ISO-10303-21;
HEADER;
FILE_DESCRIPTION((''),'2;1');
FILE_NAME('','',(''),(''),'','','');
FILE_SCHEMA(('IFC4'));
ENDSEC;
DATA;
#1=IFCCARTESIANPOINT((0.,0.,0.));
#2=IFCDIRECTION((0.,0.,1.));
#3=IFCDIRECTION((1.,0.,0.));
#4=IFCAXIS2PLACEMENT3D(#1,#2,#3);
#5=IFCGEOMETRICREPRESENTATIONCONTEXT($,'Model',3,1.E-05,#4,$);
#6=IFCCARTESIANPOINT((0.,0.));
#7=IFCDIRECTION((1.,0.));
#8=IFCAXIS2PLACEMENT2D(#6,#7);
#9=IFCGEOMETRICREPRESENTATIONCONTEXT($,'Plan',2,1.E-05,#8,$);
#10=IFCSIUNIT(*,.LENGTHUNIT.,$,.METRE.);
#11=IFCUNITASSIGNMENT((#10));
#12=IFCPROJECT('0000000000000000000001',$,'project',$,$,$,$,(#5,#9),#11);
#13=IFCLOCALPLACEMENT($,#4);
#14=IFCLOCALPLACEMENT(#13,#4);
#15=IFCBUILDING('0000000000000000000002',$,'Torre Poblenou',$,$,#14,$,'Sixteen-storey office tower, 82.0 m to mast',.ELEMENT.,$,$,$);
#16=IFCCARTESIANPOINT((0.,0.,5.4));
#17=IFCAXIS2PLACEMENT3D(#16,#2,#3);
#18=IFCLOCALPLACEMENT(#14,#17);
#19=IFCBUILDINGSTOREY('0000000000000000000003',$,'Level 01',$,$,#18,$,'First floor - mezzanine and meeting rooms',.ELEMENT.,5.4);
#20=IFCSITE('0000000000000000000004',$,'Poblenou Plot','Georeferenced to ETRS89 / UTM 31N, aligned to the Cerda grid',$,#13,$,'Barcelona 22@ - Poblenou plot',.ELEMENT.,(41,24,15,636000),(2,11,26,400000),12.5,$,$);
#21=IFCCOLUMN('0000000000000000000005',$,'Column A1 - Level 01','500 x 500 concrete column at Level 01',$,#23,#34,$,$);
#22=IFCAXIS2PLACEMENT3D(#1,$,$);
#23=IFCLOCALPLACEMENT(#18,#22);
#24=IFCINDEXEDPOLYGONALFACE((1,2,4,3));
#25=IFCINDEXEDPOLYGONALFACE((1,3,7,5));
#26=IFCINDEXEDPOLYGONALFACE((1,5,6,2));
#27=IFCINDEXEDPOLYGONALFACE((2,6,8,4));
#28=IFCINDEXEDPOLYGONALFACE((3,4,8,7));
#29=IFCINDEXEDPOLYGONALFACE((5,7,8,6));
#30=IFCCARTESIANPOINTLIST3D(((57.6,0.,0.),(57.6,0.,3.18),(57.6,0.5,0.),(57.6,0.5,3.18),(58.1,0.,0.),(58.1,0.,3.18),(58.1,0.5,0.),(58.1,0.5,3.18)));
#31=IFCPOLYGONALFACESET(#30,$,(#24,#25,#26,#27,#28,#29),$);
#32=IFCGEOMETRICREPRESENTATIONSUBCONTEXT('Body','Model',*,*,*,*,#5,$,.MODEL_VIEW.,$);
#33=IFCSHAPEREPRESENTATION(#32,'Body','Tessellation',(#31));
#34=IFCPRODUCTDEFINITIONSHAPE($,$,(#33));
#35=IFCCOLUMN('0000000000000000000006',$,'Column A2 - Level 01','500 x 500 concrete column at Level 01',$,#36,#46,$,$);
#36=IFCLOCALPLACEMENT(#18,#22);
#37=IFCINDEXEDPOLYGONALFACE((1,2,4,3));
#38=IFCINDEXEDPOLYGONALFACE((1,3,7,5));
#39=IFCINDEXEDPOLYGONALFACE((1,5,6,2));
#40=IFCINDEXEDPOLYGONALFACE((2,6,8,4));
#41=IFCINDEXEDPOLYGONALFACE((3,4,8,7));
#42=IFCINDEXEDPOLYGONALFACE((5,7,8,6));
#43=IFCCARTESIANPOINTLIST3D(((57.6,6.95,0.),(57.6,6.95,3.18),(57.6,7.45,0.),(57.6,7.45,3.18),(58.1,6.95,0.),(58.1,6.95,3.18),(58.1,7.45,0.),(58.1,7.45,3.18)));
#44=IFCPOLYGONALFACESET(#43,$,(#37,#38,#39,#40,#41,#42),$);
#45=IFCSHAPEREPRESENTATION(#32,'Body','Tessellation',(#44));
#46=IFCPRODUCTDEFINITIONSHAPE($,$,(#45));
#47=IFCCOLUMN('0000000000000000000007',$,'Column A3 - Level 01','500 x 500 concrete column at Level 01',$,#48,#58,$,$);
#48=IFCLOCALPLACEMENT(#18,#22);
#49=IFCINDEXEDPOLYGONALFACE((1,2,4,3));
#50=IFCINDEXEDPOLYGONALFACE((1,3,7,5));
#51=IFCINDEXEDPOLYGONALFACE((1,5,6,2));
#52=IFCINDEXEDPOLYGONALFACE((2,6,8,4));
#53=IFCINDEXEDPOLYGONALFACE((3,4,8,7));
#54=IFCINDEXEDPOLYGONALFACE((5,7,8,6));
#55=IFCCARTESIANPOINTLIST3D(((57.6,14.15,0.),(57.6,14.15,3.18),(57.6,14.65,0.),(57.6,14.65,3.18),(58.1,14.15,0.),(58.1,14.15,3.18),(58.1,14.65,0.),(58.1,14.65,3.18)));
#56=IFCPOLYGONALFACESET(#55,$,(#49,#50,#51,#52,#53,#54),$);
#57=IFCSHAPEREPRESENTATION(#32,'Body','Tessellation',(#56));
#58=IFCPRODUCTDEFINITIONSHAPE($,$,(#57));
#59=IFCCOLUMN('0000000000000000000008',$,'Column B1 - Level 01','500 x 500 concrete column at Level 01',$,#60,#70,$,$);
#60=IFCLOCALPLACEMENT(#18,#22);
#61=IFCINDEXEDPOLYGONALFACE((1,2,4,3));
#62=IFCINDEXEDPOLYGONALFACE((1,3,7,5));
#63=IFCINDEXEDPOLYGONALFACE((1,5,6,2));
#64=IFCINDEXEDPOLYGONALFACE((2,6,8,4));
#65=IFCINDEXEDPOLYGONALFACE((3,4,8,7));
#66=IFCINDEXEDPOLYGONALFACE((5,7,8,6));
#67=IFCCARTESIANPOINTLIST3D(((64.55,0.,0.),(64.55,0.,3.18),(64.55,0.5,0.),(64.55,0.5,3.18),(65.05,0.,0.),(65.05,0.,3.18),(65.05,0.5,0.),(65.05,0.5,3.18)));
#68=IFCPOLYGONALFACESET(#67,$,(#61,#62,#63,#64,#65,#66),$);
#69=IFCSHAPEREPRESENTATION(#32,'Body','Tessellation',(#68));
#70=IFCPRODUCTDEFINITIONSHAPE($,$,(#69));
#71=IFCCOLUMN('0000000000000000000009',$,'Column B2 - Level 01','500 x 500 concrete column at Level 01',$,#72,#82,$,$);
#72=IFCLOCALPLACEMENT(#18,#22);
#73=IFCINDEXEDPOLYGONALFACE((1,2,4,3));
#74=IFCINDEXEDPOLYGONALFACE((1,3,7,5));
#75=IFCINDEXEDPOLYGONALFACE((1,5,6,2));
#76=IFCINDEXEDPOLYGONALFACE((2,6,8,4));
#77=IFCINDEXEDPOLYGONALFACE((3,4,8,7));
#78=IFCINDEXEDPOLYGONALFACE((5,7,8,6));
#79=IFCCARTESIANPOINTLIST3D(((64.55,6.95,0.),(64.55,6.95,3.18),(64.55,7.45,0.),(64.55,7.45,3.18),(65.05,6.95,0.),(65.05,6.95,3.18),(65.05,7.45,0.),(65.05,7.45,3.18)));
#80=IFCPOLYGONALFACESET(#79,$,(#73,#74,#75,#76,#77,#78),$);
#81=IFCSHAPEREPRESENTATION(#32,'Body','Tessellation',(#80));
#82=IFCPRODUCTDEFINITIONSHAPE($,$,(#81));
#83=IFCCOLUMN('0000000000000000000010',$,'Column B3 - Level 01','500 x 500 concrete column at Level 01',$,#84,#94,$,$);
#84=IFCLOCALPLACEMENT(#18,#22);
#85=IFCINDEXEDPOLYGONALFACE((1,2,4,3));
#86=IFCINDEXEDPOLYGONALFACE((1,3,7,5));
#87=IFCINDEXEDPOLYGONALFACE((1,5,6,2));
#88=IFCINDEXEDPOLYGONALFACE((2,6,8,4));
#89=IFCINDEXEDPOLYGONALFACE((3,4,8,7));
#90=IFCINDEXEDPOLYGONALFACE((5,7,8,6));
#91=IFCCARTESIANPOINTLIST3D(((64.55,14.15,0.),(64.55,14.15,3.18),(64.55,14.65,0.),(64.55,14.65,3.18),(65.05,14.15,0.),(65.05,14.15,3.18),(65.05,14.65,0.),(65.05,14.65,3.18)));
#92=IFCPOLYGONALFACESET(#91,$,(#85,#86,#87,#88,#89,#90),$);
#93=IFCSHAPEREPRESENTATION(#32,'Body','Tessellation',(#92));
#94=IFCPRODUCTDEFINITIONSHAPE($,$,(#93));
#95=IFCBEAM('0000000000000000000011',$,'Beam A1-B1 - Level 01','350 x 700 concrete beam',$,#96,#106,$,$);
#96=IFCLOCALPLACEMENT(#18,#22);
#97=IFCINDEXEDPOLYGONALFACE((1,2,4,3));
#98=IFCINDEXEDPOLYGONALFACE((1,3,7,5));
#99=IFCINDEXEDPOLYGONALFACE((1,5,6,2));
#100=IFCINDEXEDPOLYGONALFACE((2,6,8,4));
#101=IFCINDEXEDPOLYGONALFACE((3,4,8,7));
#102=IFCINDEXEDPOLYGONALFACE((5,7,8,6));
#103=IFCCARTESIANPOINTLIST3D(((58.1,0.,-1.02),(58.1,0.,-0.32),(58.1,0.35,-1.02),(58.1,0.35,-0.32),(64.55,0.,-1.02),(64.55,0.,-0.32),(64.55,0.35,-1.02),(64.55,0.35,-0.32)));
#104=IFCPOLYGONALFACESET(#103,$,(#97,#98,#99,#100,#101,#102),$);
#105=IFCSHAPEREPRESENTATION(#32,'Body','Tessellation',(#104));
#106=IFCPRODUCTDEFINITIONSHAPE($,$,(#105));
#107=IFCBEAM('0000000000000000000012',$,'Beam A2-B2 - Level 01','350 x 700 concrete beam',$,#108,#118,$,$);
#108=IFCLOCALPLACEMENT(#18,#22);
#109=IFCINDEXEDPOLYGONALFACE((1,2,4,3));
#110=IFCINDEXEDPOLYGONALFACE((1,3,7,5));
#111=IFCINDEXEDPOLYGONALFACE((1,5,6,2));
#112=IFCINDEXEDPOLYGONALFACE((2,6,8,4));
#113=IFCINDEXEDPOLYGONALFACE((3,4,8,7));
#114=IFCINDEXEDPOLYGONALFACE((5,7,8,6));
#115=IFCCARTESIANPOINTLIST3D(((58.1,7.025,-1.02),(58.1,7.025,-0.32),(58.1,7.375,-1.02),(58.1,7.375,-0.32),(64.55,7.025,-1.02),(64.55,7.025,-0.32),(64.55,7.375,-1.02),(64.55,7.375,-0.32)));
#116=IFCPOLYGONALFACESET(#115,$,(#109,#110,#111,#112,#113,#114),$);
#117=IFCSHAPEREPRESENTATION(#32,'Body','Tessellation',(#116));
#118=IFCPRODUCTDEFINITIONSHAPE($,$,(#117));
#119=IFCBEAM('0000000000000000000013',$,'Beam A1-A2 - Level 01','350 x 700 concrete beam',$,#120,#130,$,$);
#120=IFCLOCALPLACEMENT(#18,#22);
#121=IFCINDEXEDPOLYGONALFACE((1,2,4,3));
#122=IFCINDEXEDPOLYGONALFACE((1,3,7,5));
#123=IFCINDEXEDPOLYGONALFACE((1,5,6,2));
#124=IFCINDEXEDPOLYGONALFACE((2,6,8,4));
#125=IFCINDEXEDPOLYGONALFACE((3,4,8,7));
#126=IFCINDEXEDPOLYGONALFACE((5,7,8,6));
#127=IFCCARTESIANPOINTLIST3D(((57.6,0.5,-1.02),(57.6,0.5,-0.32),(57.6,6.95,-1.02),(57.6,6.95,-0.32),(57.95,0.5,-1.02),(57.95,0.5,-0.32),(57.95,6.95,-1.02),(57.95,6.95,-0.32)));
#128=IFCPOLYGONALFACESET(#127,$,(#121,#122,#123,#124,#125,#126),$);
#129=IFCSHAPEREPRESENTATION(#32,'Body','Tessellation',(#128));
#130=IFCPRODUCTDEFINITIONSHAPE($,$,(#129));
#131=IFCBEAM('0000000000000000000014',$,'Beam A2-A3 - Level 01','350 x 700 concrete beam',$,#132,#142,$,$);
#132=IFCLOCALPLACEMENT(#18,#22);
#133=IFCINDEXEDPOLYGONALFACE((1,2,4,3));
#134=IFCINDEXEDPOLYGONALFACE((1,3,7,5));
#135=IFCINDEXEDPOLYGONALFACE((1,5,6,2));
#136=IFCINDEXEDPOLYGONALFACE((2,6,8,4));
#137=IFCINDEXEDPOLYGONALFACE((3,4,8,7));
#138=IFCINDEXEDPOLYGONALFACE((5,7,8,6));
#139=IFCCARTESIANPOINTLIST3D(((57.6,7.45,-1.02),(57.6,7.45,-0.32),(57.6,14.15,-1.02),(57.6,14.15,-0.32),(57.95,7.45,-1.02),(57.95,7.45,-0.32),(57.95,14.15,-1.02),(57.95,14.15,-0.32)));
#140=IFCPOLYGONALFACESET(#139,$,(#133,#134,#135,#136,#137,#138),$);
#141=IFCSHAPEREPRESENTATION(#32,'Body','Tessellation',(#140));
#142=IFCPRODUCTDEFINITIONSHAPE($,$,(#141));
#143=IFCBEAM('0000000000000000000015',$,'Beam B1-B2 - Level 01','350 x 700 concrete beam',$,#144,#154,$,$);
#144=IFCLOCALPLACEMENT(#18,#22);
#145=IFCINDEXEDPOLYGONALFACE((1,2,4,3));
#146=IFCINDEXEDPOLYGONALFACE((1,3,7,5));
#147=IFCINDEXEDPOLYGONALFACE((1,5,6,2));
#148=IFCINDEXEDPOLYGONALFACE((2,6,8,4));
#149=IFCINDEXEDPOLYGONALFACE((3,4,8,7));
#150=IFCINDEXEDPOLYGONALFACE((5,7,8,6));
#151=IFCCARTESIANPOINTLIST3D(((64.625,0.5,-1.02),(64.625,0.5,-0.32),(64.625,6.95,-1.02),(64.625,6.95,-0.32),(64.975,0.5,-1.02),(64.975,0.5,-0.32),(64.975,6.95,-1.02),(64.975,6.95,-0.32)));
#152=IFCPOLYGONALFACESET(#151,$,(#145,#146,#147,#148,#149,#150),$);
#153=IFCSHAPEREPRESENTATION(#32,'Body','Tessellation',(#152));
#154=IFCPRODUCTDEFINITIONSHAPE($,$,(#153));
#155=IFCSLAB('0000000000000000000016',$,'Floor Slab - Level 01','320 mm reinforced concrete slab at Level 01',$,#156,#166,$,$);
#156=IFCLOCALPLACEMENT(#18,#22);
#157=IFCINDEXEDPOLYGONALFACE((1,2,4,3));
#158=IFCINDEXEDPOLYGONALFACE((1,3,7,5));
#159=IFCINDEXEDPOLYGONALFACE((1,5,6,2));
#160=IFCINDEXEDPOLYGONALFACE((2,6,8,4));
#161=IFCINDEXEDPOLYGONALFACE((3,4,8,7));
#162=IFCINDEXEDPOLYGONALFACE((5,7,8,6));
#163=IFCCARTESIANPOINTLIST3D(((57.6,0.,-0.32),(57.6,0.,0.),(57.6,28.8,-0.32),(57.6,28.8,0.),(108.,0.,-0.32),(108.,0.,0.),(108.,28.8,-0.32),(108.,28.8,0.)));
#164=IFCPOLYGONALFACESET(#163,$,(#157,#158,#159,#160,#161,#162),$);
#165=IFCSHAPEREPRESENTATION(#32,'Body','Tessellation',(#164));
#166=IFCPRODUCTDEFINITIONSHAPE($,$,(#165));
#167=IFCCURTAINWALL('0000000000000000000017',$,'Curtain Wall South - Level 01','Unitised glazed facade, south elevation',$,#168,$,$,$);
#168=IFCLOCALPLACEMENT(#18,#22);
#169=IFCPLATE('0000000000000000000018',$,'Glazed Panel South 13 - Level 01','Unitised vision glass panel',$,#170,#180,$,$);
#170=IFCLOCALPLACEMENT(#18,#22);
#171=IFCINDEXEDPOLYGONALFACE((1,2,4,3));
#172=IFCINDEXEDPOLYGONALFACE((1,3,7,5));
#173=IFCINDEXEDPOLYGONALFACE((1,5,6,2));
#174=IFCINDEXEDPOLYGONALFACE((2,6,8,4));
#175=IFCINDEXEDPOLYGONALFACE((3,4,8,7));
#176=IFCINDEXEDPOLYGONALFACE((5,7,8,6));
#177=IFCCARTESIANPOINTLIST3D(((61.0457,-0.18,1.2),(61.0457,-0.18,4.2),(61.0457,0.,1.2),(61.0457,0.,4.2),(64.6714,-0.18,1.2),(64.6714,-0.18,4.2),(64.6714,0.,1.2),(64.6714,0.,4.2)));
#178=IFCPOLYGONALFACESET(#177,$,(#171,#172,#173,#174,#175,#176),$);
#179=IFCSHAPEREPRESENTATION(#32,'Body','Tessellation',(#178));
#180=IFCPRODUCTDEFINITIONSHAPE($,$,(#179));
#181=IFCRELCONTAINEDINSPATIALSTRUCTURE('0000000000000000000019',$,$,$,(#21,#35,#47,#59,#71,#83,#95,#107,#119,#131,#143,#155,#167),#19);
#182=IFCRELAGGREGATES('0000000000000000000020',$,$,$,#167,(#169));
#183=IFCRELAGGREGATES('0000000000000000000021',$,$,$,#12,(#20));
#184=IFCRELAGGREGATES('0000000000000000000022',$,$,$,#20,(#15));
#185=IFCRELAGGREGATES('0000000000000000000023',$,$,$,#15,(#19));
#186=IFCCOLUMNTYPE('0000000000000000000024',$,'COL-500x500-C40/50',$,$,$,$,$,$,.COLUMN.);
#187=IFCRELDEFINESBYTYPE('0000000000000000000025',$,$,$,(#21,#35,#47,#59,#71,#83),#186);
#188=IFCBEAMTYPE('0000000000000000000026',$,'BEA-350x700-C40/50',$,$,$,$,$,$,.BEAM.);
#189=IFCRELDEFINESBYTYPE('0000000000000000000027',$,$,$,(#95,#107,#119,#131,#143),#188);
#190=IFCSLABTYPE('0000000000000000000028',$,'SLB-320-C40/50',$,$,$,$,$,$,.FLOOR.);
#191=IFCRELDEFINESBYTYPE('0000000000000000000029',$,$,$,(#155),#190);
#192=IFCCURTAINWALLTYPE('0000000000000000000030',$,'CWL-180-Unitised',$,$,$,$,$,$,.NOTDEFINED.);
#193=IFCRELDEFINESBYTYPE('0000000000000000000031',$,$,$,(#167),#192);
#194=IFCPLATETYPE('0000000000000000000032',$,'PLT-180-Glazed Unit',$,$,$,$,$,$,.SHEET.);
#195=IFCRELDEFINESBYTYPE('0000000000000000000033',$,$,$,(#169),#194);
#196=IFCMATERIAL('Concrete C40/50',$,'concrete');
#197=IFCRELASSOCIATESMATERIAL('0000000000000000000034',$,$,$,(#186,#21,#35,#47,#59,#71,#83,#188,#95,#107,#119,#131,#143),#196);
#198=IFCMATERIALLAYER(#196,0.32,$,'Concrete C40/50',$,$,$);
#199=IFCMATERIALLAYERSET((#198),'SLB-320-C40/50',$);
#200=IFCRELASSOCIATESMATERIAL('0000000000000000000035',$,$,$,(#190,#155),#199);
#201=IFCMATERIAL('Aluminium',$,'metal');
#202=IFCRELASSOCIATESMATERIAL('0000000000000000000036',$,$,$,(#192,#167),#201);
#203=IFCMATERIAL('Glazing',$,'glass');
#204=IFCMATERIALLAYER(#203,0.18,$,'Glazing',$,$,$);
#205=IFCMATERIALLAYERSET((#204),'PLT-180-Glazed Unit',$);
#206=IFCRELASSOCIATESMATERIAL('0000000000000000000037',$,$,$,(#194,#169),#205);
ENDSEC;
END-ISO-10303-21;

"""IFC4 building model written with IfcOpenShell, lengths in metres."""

from ifc_helpers import new_model, si_unit, frame, origin_with_axes, origin_2d_with_axis, place, context, subcontext, project, spatial, line, indexed_curve, rectangle, outline, extrude, material, layer, layer_set, layer_usage, material_profile, profile_set, profile_usage, type_object, element, aggregate, save


model = new_model("IFC4")

# Units and contexts
model_context = context("Model", 3, precision=1e-05, world=origin_with_axes())
plan_context = context("Plan", 2, precision=1e-05, world=origin_2d_with_axis())
body_context = subcontext(model_context, "Body", "Model", "MODEL_VIEW")
ifc_project = project(units=[si_unit("LENGTHUNIT", "METRE")], contexts=[model_context, plan_context])

# Site, building, storey
site_placement = place(None, origin_with_axes())
site = spatial("IfcSite", under=ifc_project, at=site_placement, Name="Poblenou Plot", Description="Georeferenced to ETRS89 / UTM 31N, aligned to the Cerda grid", LongName="Barcelona 22@ - Poblenou plot", CompositionType="ELEMENT", RefLatitude=(41, 24, 15, 636000), RefLongitude=(2, 11, 26, 400000), RefElevation=12.5)
building_placement = place(site_placement, origin_with_axes())
building = spatial("IfcBuilding", under=site, at=building_placement, Name="Torre Poblenou", LongName="Sixteen-storey office tower, 82.0 m to mast", CompositionType="ELEMENT")
storey_placement = place(building_placement, frame((0.0, 0.0, 5.4), z_axis=(0.0, 0.0, 1.0), x_axis=(1.0, 0.0, 0.0)))
storey = spatial("IfcBuildingStorey", under=building, at=storey_placement, Name="Level 01", LongName="First floor - mezzanine and meeting rooms", CompositionType="ELEMENT", Elevation=5.4)

# Columns
ifc_material_1 = material(Name="Concrete C40/50", Category="concrete")
ifc_material_profile_1 = material_profile(ifc_material_1, rectangle(XDim=0.5, YDim=0.5))
ifc_profile_set_1 = profile_set([ifc_material_profile_1], Name="COL-500x500-C40/50")
ifc_profile_usage_1 = profile_usage(ifc_profile_set_1)
column_type = type_object("IfcColumnType", Name="COL-500x500-C40/50", PredefinedType="COLUMN", material=ifc_profile_set_1)
column_1_placement = place(storey_placement, frame((57.6, 0.0, 0.0), z_axis=(0.0, 0.0, 1.0), x_axis=(1.0, 0.0, 0.0)))
element("IfcColumn", 1, at=column_1_placement, inside=storey, type_object=column_type, material=ifc_profile_usage_1, Name="Column A1 - Level 01", Description="500 x 500 concrete column at Level 01", context=body_context, shape_type="SweptSolid", body=[
    extrude(outline(indexed_curve([(0.0, 0.0), (0.5, 0.0), (0.5, 0.5), (0.0, 0.5)], segments=[line(1, 2, 3, 4, 1)])), origin_with_axes(), (0.0, 0.0, 1.0), 3.18),
])
ifc_profile_usage_2 = profile_usage(ifc_profile_set_1)
column_2_placement = place(storey_placement, frame((57.6, 6.95, 0.0), z_axis=(0.0, 0.0, 1.0), x_axis=(1.0, 0.0, 0.0)))
element("IfcColumn", 2, at=column_2_placement, inside=storey, type_object=column_type, material=ifc_profile_usage_2, Name="Column A2 - Level 01", Description="500 x 500 concrete column at Level 01", context=body_context, shape_type="SweptSolid", body=[
    extrude(outline(indexed_curve([(0.0, 0.0), (0.5, 0.0), (0.5, 0.5), (0.0, 0.5)], segments=[line(1, 2, 3, 4, 1)])), origin_with_axes(), (0.0, 0.0, 1.0), 3.18),
])
ifc_profile_usage_3 = profile_usage(ifc_profile_set_1)
column_3_placement = place(storey_placement, frame((57.6, 14.15, 0.0), z_axis=(0.0, 0.0, 1.0), x_axis=(1.0, 0.0, 0.0)))
element("IfcColumn", 3, at=column_3_placement, inside=storey, type_object=column_type, material=ifc_profile_usage_3, Name="Column A3 - Level 01", Description="500 x 500 concrete column at Level 01", context=body_context, shape_type="SweptSolid", body=[
    extrude(outline(indexed_curve([(0.0, 0.0), (0.5, 0.0), (0.5, 0.5), (0.0, 0.5)], segments=[line(1, 2, 3, 4, 1)])), origin_with_axes(), (0.0, 0.0, 1.0), 3.18),
])
ifc_profile_usage_4 = profile_usage(ifc_profile_set_1)
column_4_placement = place(storey_placement, frame((64.55, 0.0, 0.0), z_axis=(0.0, 0.0, 1.0), x_axis=(1.0, 0.0, 0.0)))
element("IfcColumn", 4, at=column_4_placement, inside=storey, type_object=column_type, material=ifc_profile_usage_4, Name="Column B1 - Level 01", Description="500 x 500 concrete column at Level 01", context=body_context, shape_type="SweptSolid", body=[
    extrude(outline(indexed_curve([(0.0, 0.0), (0.5, 0.0), (0.5, 0.5), (0.0, 0.5)], segments=[line(1, 2, 3, 4, 1)])), origin_with_axes(), (0.0, 0.0, 1.0), 3.18),
])
ifc_profile_usage_5 = profile_usage(ifc_profile_set_1)
column_5_placement = place(storey_placement, frame((64.55, 6.95, 0.0), z_axis=(0.0, 0.0, 1.0), x_axis=(1.0, 0.0, 0.0)))
element("IfcColumn", 5, at=column_5_placement, inside=storey, type_object=column_type, material=ifc_profile_usage_5, Name="Column B2 - Level 01", Description="500 x 500 concrete column at Level 01", context=body_context, shape_type="SweptSolid", body=[
    extrude(outline(indexed_curve([(0.0, 0.0), (0.5, 0.0), (0.5, 0.5), (0.0, 0.5)], segments=[line(1, 2, 3, 4, 1)])), origin_with_axes(), (0.0, 0.0, 1.0), 3.18),
])
ifc_profile_usage_6 = profile_usage(ifc_profile_set_1)
column_6_placement = place(storey_placement, frame((64.55, 14.15, 0.0), z_axis=(0.0, 0.0, 1.0), x_axis=(1.0, 0.0, 0.0)))
element("IfcColumn", 6, at=column_6_placement, inside=storey, type_object=column_type, material=ifc_profile_usage_6, Name="Column B3 - Level 01", Description="500 x 500 concrete column at Level 01", context=body_context, shape_type="SweptSolid", body=[
    extrude(outline(indexed_curve([(0.0, 0.0), (0.5, 0.0), (0.5, 0.5), (0.0, 0.5)], segments=[line(1, 2, 3, 4, 1)])), origin_with_axes(), (0.0, 0.0, 1.0), 3.18),
])

# Beams
ifc_material_profile_2 = material_profile(ifc_material_1, rectangle(XDim=0.35, YDim=0.7))
ifc_profile_set_2 = profile_set([ifc_material_profile_2], Name="BEA-350x700-C40/50")
ifc_profile_usage_7 = profile_usage(ifc_profile_set_2)
beam_type = type_object("IfcBeamType", Name="BEA-350x700-C40/50", PredefinedType="BEAM", material=ifc_profile_set_2)
beam_1_placement = place(storey_placement, frame((58.1, 0.0, -1.02), z_axis=(0.0, 0.0, 1.0), x_axis=(1.0, 0.0, 0.0)))
element("IfcBeam", 7, at=beam_1_placement, inside=storey, type_object=beam_type, material=ifc_profile_usage_7, Name="Beam A1-B1 - Level 01", Description="350 x 700 concrete beam", context=body_context, shape_type="SweptSolid", body=[
    extrude(outline(indexed_curve([(0.0, 0.0), (6.45, 0.0), (6.45, 0.35), (0.0, 0.35)], segments=[line(1, 2, 3, 4, 1)])), origin_with_axes(), (0.0, 0.0, 1.0), 0.7),
])
ifc_profile_usage_8 = profile_usage(ifc_profile_set_2)
beam_2_placement = place(storey_placement, frame((58.1, 7.025, -1.02), z_axis=(0.0, 0.0, 1.0), x_axis=(1.0, 0.0, 0.0)))
element("IfcBeam", 8, at=beam_2_placement, inside=storey, type_object=beam_type, material=ifc_profile_usage_8, Name="Beam A2-B2 - Level 01", Description="350 x 700 concrete beam", context=body_context, shape_type="SweptSolid", body=[
    extrude(outline(indexed_curve([(0.0, 0.0), (6.45, 0.0), (6.45, 0.35), (0.0, 0.35)], segments=[line(1, 2, 3, 4, 1)])), origin_with_axes(), (0.0, 0.0, 1.0), 0.7),
])
ifc_profile_usage_9 = profile_usage(ifc_profile_set_2)
beam_3_placement = place(storey_placement, frame((57.95, 0.5, -1.02), z_axis=(0.0, 0.0, 1.0), x_axis=(0.0, 1.0, 0.0)))
element("IfcBeam", 9, at=beam_3_placement, inside=storey, type_object=beam_type, material=ifc_profile_usage_9, Name="Beam A1-A2 - Level 01", Description="350 x 700 concrete beam", context=body_context, shape_type="SweptSolid", body=[
    extrude(outline(indexed_curve([(0.0, 0.0), (6.45, 0.0), (6.45, 0.35), (0.0, 0.35)], segments=[line(1, 2, 3, 4, 1)])), origin_with_axes(), (0.0, 0.0, 1.0), 0.7),
])
ifc_profile_usage_10 = profile_usage(ifc_profile_set_2)
beam_4_placement = place(storey_placement, frame((57.95, 7.45, -1.02), z_axis=(0.0, 0.0, 1.0), x_axis=(0.0, 1.0, 0.0)))
element("IfcBeam", 10, at=beam_4_placement, inside=storey, type_object=beam_type, material=ifc_profile_usage_10, Name="Beam A2-A3 - Level 01", Description="350 x 700 concrete beam", context=body_context, shape_type="SweptSolid", body=[
    extrude(outline(indexed_curve([(0.0, 0.0), (6.7, 0.0), (6.7, 0.35), (0.0, 0.35)], segments=[line(1, 2, 3, 4, 1)])), origin_with_axes(), (0.0, 0.0, 1.0), 0.7),
])
ifc_profile_usage_11 = profile_usage(ifc_profile_set_2)
beam_5_placement = place(storey_placement, frame((64.975, 0.5, -1.02), z_axis=(0.0, 0.0, 1.0), x_axis=(0.0, 1.0, 0.0)))
element("IfcBeam", 11, at=beam_5_placement, inside=storey, type_object=beam_type, material=ifc_profile_usage_11, Name="Beam B1-B2 - Level 01", Description="350 x 700 concrete beam", context=body_context, shape_type="SweptSolid", body=[
    extrude(outline(indexed_curve([(0.0, 0.0), (6.45, 0.0), (6.45, 0.35), (0.0, 0.35)], segments=[line(1, 2, 3, 4, 1)])), origin_with_axes(), (0.0, 0.0, 1.0), 0.7),
])

# Slab
ifc_layer_1 = layer(ifc_material_1, 0.32, Name="Concrete C40/50")
ifc_layer_set_1 = layer_set([ifc_layer_1], Name="SLB-320-C40/50")
ifc_layer_usage_1 = layer_usage(ifc_layer_set_1, "AXIS3", "POSITIVE", 0.0)
slab_type = type_object("IfcSlabType", Name="SLB-320-C40/50", PredefinedType="FLOOR", material=ifc_layer_set_1)
slab_placement = place(storey_placement, frame((57.6, 0.0, -0.32), z_axis=(0.0, 0.0, 1.0), x_axis=(1.0, 0.0, 0.0)))
element("IfcSlab", 12, at=slab_placement, inside=storey, type_object=slab_type, material=ifc_layer_usage_1, Name="Floor Slab - Level 01", Description="320 mm reinforced concrete slab at Level 01", context=body_context, shape_type="SweptSolid", body=[
    extrude(outline(indexed_curve([(0.0, 0.0), (50.4, 0.0), (50.4, 28.8), (0.0, 28.8)], segments=[line(1, 2, 3, 4, 1)])), origin_with_axes(), (0.0, 0.0, 1.0), 0.32),
])

# Curtain wall, plate
ifc_material_2 = material(Name="Aluminium", Category="metal")
curtain_wall_type = type_object("IfcCurtainWallType", Name="CWL-180-Unitised", PredefinedType="NOTDEFINED", material=ifc_material_2)
curtain_wall_1_placement = place(storey_placement, frame((108.18, 0.0, 0.0), z_axis=(0.0, 0.0, 1.0), x_axis=(-1.0, 0.0, 0.0)))
curtain_wall_1 = element("IfcCurtainWall", 13, at=curtain_wall_1_placement, inside=storey, type_object=curtain_wall_type, material=ifc_material_2, Name="Curtain Wall South - Level 01", Description="Unitised glazed facade, south elevation")
ifc_material_3 = material(Name="Glazing", Category="glass")
ifc_layer_2 = layer(ifc_material_3, 0.18, Name="Glazing")
ifc_layer_set_2 = layer_set([ifc_layer_2], Name="PLT-180-Glazed Unit")
ifc_layer_usage_2 = layer_usage(ifc_layer_set_2, "AXIS2", "POSITIVE", 0.0)
plate_type_1 = type_object("IfcPlateType", Name="PLT-180-Glazed Unit", PredefinedType="SHEET", material=ifc_layer_set_2)
plate_1_placement = place(curtain_wall_1_placement, frame((43.5086, 0.0, 1.2), z_axis=(0.0, 0.0, 1.0), x_axis=(1.0, 0.0, 0.0)))
plate_1 = element("IfcPlate", 14, at=plate_1_placement, type_object=plate_type_1, material=ifc_layer_usage_2, Name="Glazed Panel South 13 - Level 01", Description="Unitised vision glass panel", context=body_context, shape_type="SweptSolid", body=[
    extrude(outline(indexed_curve([(0.0, 0.0), (3.6257, 0.0), (3.6257, 0.18), (0.0, 0.18)], segments=[line(1, 2, 3, 4, 1)])), origin_with_axes(), (0.0, 0.0, 1.0), 3.0),
])

aggregate(curtain_wall_1, [plate_1])

save(model, "model.ifc")
